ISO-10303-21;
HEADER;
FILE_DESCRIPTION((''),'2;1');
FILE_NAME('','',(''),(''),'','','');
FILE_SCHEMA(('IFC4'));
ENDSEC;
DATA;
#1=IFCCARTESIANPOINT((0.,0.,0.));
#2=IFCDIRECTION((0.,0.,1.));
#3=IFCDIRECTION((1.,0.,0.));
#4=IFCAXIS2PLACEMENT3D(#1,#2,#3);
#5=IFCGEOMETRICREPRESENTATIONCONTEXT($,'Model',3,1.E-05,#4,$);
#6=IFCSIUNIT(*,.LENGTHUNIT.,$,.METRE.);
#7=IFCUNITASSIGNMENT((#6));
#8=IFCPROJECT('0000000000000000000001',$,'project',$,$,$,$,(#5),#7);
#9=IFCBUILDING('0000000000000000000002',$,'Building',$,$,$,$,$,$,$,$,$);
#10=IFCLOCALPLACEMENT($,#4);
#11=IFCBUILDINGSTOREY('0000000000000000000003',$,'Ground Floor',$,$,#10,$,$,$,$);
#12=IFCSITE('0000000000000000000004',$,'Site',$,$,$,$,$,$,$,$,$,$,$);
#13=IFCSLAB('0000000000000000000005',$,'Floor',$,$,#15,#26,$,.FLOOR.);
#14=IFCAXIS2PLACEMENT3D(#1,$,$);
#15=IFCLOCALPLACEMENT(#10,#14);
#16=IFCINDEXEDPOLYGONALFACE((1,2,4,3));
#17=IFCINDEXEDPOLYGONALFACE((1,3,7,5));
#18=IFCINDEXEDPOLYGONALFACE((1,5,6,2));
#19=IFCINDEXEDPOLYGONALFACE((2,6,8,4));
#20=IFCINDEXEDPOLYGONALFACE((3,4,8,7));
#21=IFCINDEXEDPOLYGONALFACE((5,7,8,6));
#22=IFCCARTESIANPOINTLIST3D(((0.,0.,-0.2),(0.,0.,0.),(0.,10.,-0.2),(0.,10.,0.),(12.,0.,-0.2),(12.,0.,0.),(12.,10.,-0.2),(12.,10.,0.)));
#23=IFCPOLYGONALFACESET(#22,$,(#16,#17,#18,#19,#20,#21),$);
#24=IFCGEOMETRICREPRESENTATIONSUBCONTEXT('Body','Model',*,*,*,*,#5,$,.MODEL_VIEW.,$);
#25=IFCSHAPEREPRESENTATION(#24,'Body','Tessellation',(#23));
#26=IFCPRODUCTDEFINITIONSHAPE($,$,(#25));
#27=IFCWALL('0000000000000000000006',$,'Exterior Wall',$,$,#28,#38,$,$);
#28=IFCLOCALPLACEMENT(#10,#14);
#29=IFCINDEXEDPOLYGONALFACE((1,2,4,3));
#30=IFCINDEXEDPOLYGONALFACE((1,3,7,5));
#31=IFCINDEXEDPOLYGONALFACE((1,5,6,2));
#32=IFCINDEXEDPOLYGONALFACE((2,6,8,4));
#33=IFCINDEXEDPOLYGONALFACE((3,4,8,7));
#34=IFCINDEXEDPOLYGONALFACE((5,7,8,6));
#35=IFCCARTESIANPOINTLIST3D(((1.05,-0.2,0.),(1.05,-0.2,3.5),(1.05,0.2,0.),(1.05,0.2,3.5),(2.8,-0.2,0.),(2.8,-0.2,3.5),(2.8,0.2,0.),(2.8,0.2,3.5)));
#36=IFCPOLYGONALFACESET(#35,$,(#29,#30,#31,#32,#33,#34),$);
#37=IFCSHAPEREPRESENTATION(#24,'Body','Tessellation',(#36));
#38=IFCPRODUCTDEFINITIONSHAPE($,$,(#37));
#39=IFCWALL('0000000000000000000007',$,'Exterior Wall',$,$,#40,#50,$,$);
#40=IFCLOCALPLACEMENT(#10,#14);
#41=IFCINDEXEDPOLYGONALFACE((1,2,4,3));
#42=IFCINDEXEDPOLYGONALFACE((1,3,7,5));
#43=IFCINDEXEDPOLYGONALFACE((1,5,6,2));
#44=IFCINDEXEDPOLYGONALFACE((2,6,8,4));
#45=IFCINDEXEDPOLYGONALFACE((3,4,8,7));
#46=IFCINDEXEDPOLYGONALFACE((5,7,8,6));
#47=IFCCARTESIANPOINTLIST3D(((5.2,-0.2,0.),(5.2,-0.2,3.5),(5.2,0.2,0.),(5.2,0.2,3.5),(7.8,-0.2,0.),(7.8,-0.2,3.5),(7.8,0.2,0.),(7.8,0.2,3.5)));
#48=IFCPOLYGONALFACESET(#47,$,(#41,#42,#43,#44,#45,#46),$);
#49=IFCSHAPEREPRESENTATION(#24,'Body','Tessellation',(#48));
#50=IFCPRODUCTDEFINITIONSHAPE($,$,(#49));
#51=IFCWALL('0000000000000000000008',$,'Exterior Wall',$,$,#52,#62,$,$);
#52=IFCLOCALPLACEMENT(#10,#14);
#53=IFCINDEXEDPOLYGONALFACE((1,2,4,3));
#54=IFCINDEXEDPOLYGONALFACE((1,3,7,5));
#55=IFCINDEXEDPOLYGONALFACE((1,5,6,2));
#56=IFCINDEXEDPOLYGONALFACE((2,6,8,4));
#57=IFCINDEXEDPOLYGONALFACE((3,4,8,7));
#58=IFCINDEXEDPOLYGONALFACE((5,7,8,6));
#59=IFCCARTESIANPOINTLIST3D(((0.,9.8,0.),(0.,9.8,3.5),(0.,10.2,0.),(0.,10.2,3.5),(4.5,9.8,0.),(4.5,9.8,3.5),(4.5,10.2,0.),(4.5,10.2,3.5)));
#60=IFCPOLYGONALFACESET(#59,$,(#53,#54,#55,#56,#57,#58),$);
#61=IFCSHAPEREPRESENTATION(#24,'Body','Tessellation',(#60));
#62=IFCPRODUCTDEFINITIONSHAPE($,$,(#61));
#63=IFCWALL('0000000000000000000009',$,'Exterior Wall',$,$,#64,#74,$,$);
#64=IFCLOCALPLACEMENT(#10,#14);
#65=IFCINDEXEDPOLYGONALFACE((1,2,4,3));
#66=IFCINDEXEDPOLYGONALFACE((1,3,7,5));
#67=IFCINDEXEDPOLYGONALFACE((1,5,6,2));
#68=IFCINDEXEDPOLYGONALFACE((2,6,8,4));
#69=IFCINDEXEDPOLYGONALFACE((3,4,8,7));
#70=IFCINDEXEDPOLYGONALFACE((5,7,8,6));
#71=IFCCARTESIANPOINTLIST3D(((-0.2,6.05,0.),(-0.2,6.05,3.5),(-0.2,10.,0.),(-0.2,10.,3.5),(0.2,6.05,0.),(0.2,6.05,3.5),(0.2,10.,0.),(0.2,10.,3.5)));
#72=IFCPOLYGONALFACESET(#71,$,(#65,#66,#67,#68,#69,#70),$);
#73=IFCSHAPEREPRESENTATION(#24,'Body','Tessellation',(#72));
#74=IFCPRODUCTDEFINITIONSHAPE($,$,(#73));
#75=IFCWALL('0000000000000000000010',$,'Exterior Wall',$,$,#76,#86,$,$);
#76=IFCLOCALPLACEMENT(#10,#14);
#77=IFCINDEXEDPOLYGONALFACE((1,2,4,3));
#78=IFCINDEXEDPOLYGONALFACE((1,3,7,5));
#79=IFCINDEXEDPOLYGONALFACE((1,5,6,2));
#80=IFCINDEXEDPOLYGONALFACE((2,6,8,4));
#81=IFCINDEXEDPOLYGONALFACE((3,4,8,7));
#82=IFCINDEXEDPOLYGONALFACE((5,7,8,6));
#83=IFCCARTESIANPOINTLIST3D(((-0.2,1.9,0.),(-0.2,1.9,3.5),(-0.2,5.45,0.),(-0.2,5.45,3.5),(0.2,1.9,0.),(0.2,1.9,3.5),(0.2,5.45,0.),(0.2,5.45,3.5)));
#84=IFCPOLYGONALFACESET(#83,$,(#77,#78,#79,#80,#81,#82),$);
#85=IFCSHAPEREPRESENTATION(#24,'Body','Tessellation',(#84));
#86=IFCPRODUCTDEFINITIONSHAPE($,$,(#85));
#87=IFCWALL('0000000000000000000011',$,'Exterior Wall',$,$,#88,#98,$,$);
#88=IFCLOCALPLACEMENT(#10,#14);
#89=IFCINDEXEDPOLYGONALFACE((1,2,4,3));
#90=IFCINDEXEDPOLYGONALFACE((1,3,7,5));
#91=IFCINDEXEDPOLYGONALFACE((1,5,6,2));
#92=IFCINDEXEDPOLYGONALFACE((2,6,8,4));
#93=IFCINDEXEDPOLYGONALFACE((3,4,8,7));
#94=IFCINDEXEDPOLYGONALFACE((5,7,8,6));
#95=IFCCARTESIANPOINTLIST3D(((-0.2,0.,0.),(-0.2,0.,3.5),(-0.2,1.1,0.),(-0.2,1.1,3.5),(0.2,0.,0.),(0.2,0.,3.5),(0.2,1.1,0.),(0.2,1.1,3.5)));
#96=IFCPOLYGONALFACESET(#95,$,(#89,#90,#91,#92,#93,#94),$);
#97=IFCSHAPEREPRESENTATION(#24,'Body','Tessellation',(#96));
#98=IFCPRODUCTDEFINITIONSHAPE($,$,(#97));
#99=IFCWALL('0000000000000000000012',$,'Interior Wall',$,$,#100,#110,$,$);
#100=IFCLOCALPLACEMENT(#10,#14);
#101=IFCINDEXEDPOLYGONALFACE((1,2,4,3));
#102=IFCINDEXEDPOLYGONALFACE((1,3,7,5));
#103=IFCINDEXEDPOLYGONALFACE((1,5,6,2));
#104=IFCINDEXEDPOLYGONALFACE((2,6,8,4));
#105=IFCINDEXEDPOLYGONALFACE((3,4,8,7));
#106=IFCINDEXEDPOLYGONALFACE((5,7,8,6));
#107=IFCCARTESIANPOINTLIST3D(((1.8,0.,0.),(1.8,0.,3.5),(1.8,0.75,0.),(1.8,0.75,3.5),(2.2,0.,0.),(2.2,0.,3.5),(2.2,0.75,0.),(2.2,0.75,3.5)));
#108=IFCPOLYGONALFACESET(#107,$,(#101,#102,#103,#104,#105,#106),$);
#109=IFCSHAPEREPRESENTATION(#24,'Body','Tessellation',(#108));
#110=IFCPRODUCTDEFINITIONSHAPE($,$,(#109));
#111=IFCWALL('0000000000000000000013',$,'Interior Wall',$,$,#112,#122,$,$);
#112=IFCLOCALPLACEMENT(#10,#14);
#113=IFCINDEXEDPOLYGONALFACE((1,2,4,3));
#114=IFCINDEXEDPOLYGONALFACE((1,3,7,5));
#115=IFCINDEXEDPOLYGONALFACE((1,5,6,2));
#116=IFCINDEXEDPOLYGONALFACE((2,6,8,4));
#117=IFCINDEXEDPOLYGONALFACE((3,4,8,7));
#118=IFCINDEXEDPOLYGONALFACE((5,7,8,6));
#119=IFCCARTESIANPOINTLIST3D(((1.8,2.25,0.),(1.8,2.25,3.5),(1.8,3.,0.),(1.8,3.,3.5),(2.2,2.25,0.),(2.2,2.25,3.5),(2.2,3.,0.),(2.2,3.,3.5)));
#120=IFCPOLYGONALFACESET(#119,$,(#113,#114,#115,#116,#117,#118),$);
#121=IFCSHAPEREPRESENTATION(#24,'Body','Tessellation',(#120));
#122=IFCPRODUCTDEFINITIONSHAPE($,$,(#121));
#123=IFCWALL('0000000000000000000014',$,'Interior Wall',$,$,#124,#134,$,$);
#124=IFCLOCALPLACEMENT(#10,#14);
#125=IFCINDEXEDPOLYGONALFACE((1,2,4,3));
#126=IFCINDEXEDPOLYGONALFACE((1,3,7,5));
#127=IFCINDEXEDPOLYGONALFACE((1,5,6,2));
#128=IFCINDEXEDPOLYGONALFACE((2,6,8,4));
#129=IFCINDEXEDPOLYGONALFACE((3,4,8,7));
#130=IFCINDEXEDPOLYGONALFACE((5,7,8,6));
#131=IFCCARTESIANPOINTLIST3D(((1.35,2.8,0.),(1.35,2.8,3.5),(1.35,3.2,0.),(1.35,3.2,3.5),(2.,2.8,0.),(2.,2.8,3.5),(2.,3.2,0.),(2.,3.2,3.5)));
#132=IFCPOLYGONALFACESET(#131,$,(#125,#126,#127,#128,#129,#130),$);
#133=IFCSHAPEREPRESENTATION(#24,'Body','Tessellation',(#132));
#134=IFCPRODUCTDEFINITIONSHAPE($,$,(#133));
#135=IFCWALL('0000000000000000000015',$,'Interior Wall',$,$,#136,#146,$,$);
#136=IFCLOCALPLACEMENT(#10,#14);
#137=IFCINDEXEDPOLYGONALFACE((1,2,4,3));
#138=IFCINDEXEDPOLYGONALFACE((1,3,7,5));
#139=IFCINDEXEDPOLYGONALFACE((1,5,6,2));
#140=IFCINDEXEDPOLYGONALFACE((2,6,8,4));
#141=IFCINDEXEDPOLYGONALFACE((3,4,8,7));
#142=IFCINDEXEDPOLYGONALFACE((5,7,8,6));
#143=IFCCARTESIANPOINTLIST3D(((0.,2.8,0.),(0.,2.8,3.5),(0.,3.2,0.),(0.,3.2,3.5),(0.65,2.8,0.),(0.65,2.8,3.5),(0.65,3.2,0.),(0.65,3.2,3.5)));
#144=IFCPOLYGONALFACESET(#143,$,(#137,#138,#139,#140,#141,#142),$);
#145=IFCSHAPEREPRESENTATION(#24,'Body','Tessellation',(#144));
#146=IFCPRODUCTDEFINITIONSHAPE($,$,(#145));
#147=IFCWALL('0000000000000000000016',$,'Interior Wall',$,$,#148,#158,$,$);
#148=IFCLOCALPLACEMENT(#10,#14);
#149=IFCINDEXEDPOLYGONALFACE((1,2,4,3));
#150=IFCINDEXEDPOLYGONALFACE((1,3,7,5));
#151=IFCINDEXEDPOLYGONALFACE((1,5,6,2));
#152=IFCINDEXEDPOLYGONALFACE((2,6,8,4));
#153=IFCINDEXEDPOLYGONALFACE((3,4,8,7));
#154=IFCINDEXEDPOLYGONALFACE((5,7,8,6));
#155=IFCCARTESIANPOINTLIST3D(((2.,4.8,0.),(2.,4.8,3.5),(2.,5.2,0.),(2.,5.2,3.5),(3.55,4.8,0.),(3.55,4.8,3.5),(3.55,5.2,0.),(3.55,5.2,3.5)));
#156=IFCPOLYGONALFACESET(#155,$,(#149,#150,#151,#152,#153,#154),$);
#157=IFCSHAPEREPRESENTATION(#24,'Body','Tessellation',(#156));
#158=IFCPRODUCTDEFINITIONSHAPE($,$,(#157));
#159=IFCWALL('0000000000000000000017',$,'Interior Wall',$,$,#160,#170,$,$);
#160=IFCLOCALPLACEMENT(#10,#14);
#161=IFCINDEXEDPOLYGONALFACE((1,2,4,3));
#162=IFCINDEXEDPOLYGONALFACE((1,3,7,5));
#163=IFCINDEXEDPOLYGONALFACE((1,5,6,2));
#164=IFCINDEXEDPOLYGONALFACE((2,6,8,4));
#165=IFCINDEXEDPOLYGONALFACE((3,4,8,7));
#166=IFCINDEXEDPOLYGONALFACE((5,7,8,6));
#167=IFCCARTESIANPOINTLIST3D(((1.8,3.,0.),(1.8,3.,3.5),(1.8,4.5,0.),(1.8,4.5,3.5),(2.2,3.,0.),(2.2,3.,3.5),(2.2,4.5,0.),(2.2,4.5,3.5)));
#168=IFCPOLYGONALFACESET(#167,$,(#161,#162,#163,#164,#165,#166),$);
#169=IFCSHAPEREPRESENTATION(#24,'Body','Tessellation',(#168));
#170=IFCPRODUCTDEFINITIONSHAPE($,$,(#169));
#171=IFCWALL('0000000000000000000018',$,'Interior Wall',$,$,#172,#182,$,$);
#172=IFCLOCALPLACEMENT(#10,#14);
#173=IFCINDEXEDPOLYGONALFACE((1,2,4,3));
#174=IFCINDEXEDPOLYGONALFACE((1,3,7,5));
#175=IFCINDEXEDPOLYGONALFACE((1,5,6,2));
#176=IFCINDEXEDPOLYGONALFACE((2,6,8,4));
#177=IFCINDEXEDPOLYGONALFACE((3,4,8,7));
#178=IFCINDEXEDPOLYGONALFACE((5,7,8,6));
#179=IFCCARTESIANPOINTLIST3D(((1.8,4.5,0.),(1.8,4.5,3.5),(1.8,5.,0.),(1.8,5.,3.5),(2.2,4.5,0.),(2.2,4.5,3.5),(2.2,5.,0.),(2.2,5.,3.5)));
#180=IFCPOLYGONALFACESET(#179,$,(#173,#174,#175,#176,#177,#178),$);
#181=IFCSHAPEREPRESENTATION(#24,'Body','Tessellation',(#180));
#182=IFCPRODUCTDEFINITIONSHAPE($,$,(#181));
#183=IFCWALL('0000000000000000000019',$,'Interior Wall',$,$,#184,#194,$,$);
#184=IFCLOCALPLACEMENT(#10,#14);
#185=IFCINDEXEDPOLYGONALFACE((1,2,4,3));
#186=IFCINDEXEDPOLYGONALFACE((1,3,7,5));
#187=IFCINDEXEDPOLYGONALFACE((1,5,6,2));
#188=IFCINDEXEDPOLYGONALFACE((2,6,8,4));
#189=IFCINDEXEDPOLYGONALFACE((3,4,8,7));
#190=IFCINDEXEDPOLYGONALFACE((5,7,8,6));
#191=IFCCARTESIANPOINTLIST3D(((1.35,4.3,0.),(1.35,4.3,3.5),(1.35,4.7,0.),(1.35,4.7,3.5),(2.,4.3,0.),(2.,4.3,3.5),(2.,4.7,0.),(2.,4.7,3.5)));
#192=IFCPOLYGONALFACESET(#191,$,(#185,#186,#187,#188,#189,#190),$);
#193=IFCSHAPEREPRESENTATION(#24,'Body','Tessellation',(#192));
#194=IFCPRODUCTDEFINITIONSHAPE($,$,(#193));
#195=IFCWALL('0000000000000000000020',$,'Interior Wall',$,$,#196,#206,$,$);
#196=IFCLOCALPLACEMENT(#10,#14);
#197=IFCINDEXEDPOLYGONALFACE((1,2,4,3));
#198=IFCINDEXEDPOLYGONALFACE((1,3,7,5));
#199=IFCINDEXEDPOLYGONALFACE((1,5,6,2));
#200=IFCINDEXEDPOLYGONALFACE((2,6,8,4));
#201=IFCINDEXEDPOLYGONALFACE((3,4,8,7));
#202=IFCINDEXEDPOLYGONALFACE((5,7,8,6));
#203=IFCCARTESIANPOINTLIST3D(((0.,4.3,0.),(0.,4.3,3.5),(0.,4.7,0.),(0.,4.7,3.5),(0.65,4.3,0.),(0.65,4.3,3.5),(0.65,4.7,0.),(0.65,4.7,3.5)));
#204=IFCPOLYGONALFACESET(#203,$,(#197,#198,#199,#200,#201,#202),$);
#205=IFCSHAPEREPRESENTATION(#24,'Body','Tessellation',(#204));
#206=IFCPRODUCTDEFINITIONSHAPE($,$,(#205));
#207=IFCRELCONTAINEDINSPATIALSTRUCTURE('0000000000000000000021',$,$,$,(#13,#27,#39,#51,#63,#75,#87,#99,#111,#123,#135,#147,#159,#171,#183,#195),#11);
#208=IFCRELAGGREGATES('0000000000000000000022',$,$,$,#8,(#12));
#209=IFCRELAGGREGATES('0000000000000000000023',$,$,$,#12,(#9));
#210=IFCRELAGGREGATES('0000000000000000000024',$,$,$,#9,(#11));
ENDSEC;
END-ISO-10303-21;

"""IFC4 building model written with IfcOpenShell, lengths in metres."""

from ifc_helpers import new_model, si_unit, frame, origin_with_axes, place, context, subcontext, project, spatial, indexed_curve, outline, extrude, element, save


model = new_model("IFC4")

# Units and contexts
model_context = context("Model", 3, precision=1e-05, world=origin_with_axes())
body_context = subcontext(model_context, "Body", "Model", "MODEL_VIEW")
ifc_project = project(units=[si_unit("LENGTHUNIT", "METRE")], contexts=[model_context])

# Site, building, storey
site = spatial("IfcSite", under=ifc_project, Name="Site")
building = spatial("IfcBuilding", under=site, Name="Building")
storey_placement = place(None, origin_with_axes())
storey = spatial("IfcBuildingStorey", under=building, at=storey_placement, Name="Ground Floor")

# Slab
slab_placement = place(storey_placement, frame((0.0, 0.0, -0.2), z_axis=(0.0, 0.0, 1.0), x_axis=(1.0, 0.0, 0.0)))
element("IfcSlab", 1, at=slab_placement, inside=storey, Name="Floor", PredefinedType="FLOOR", context=body_context, shape_type="SweptSolid", body=[
    extrude(outline(indexed_curve([(0.0, 0.0), (12.0, 0.0), (12.0, 10.0), (0.0, 10.0)])), None, (0.0, 0.0, 1.0), 0.2),
])

# Walls
wall_1_placement = place(storey_placement, frame((1.05, 0.0, 0.0), z_axis=(0.0, 0.0, 1.0), x_axis=(1.0, 0.0, 0.0)))
element("IfcWall", 2, at=wall_1_placement, inside=storey, Name="Exterior Wall", context=body_context, shape_type="SweptSolid", body=[
    extrude(outline(indexed_curve([(0.0, 0.0), (0.0, 0.4), (1.75, 0.4), (1.75, 0.0), (0.0, 0.0)], self_intersect=False)), frame((0.0, -0.2, 0.0), z_axis=(0.0, 0.0, 1.0), x_axis=(1.0, 0.0, 0.0)), (0.0, 0.0, 1.0), 3.5),
])
wall_2_placement = place(storey_placement, frame((5.2, 0.0, 0.0), z_axis=(0.0, 0.0, 1.0), x_axis=(1.0, 0.0, 0.0)))
element("IfcWall", 3, at=wall_2_placement, inside=storey, Name="Exterior Wall", context=body_context, shape_type="SweptSolid", body=[
    extrude(outline(indexed_curve([(0.0, 0.0), (0.0, 0.4), (2.6, 0.4), (2.6, 0.0), (0.0, 0.0)], self_intersect=False)), frame((0.0, -0.2, 0.0), z_axis=(0.0, 0.0, 1.0), x_axis=(1.0, 0.0, 0.0)), (0.0, 0.0, 1.0), 3.5),
])
wall_3_placement = place(storey_placement, frame((4.5, 10.0, 0.0), z_axis=(0.0, 0.0, 1.0), x_axis=(-1.0, 0.0, 0.0)))
element("IfcWall", 4, at=wall_3_placement, inside=storey, Name="Exterior Wall", context=body_context, shape_type="SweptSolid", body=[
    extrude(outline(indexed_curve([(0.0, 0.0), (0.0, 0.4), (4.5, 0.4), (4.5, 0.0), (0.0, 0.0)], self_intersect=False)), frame((0.0, -0.2, 0.0), z_axis=(0.0, 0.0, 1.0), x_axis=(1.0, 0.0, 0.0)), (0.0, 0.0, 1.0), 3.5),
])
wall_4_placement = place(storey_placement, frame((0.0, 10.0, 0.0), z_axis=(0.0, 0.0, 1.0), x_axis=(0.0, -1.0, 0.0)))
element("IfcWall", 5, at=wall_4_placement, inside=storey, Name="Exterior Wall", context=body_context, shape_type="SweptSolid", body=[
    extrude(outline(indexed_curve([(0.0, 0.0), (0.0, 0.4), (3.95, 0.4), (3.95, 0.0), (0.0, 0.0)], self_intersect=False)), frame((0.0, -0.2, 0.0), z_axis=(0.0, 0.0, 1.0), x_axis=(1.0, 0.0, 0.0)), (0.0, 0.0, 1.0), 3.5),
])
wall_5_placement = place(storey_placement, frame((0.0, 5.45, 0.0), z_axis=(0.0, 0.0, 1.0), x_axis=(0.0, -1.0, 0.0)))
element("IfcWall", 6, at=wall_5_placement, inside=storey, Name="Exterior Wall", context=body_context, shape_type="SweptSolid", body=[
    extrude(outline(indexed_curve([(0.0, 0.0), (0.0, 0.4), (3.55, 0.4), (3.55, 0.0), (0.0, 0.0)], self_intersect=False)), frame((0.0, -0.2, 0.0), z_axis=(0.0, 0.0, 1.0), x_axis=(1.0, 0.0, 0.0)), (0.0, 0.0, 1.0), 3.5),
])
wall_6_placement = place(storey_placement, frame((0.0, 1.1, 0.0), z_axis=(0.0, 0.0, 1.0), x_axis=(0.0, -1.0, 0.0)))
element("IfcWall", 7, at=wall_6_placement, inside=storey, Name="Exterior Wall", context=body_context, shape_type="SweptSolid", body=[
    extrude(outline(indexed_curve([(0.0, 0.0), (0.0, 0.4), (1.1, 0.4), (1.1, 0.0), (0.0, 0.0)], self_intersect=False)), frame((0.0, -0.2, 0.0), z_axis=(0.0, 0.0, 1.0), x_axis=(1.0, 0.0, 0.0)), (0.0, 0.0, 1.0), 3.5),
])
for number, where, z_axis, x_axis, name in (
    (8, (2.0, 0.0, 0.0), (0.0, 0.0, 1.0), (0.0, 1.0, 0.0), "Interior Wall"),
    (9, (2.0, 2.25, 0.0), (0.0, 0.0, 1.0), (0.0, 1.0, 0.0), "Interior Wall"),
):
    element("IfcWall", number, at=place(storey_placement, frame(where, z_axis=z_axis, x_axis=x_axis)), inside=storey, Name=name, context=body_context, shape_type="SweptSolid", body=[
        extrude(outline(indexed_curve([(0.0, 0.0), (0.0, 0.4), (0.75, 0.4), (0.75, 0.0), (0.0, 0.0)], self_intersect=False)), frame((0.0, -0.2, 0.0), z_axis=(0.0, 0.0, 1.0), x_axis=(1.0, 0.0, 0.0)), (0.0, 0.0, 1.0), 3.5),
    ])
for number, where, z_axis, x_axis, name in (
    (10, (2.0, 3.0, 0.0), (0.0, 0.0, 1.0), (-1.0, 0.0, 0.0), "Interior Wall"),
    (11, (0.65, 3.0, 0.0), (0.0, 0.0, 1.0), (-1.0, 0.0, 0.0), "Interior Wall"),
):
    element("IfcWall", number, at=place(storey_placement, frame(where, z_axis=z_axis, x_axis=x_axis)), inside=storey, Name=name, context=body_context, shape_type="SweptSolid", body=[
        extrude(outline(indexed_curve([(0.0, 0.0), (0.0, 0.4), (0.65, 0.4), (0.65, 0.0), (0.0, 0.0)], self_intersect=False)), frame((0.0, -0.2, 0.0), z_axis=(0.0, 0.0, 1.0), x_axis=(1.0, 0.0, 0.0)), (0.0, 0.0, 1.0), 3.5),
    ])
wall_7_placement = place(storey_placement, frame((3.55, 5.0, 0.0), z_axis=(0.0, 0.0, 1.0), x_axis=(-1.0, 0.0, 0.0)))
element("IfcWall", 12, at=wall_7_placement, inside=storey, Name="Interior Wall", context=body_context, shape_type="SweptSolid", body=[
    extrude(outline(indexed_curve([(0.0, 0.0), (0.0, 0.4), (1.55, 0.4), (1.55, 0.0), (0.0, 0.0)], self_intersect=False)), frame((0.0, -0.2, 0.0), z_axis=(0.0, 0.0, 1.0), x_axis=(1.0, 0.0, 0.0)), (0.0, 0.0, 1.0), 3.5),
])
wall_8_placement = place(storey_placement, frame((2.0, 4.5, 0.0), z_axis=(0.0, 0.0, 1.0), x_axis=(0.0, -1.0, 0.0)))
element("IfcWall", 13, at=wall_8_placement, inside=storey, Name="Interior Wall", context=body_context, shape_type="SweptSolid", body=[
    extrude(outline(indexed_curve([(0.0, 0.0), (0.0, 0.4), (1.5, 0.4), (1.5, 0.0), (0.0, 0.0)], self_intersect=False)), frame((0.0, -0.2, 0.0), z_axis=(0.0, 0.0, 1.0), x_axis=(1.0, 0.0, 0.0)), (0.0, 0.0, 1.0), 3.5),
])
wall_9_placement = place(storey_placement, frame((2.0, 5.0, 0.0), z_axis=(0.0, 0.0, 1.0), x_axis=(0.0, -1.0, 0.0)))
element("IfcWall", 14, at=wall_9_placement, inside=storey, Name="Interior Wall", context=body_context, shape_type="SweptSolid", body=[
    extrude(outline(indexed_curve([(0.0, 0.0), (0.0, 0.4), (0.5, 0.4), (0.5, 0.0), (0.0, 0.0)], self_intersect=False)), frame((0.0, -0.2, 0.0), z_axis=(0.0, 0.0, 1.0), x_axis=(1.0, 0.0, 0.0)), (0.0, 0.0, 1.0), 3.5),
])
for number, where, z_axis, x_axis, name in (
    (15, (2.0, 4.5, 0.0), (0.0, 0.0, 1.0), (-1.0, 0.0, 0.0), "Interior Wall"),
    (16, (0.65, 4.5, 0.0), (0.0, 0.0, 1.0), (-1.0, 0.0, 0.0), "Interior Wall"),
):
    element("IfcWall", number, at=place(storey_placement, frame(where, z_axis=z_axis, x_axis=x_axis)), inside=storey, Name=name, context=body_context, shape_type="SweptSolid", body=[
        extrude(outline(indexed_curve([(0.0, 0.0), (0.0, 0.4), (0.65, 0.4), (0.65, 0.0), (0.0, 0.0)], self_intersect=False)), frame((0.0, -0.2, 0.0), z_axis=(0.0, 0.0, 1.0), x_axis=(1.0, 0.0, 0.0)), (0.0, 0.0, 1.0), 3.5),
    ])

save(model, "model.ifc")
